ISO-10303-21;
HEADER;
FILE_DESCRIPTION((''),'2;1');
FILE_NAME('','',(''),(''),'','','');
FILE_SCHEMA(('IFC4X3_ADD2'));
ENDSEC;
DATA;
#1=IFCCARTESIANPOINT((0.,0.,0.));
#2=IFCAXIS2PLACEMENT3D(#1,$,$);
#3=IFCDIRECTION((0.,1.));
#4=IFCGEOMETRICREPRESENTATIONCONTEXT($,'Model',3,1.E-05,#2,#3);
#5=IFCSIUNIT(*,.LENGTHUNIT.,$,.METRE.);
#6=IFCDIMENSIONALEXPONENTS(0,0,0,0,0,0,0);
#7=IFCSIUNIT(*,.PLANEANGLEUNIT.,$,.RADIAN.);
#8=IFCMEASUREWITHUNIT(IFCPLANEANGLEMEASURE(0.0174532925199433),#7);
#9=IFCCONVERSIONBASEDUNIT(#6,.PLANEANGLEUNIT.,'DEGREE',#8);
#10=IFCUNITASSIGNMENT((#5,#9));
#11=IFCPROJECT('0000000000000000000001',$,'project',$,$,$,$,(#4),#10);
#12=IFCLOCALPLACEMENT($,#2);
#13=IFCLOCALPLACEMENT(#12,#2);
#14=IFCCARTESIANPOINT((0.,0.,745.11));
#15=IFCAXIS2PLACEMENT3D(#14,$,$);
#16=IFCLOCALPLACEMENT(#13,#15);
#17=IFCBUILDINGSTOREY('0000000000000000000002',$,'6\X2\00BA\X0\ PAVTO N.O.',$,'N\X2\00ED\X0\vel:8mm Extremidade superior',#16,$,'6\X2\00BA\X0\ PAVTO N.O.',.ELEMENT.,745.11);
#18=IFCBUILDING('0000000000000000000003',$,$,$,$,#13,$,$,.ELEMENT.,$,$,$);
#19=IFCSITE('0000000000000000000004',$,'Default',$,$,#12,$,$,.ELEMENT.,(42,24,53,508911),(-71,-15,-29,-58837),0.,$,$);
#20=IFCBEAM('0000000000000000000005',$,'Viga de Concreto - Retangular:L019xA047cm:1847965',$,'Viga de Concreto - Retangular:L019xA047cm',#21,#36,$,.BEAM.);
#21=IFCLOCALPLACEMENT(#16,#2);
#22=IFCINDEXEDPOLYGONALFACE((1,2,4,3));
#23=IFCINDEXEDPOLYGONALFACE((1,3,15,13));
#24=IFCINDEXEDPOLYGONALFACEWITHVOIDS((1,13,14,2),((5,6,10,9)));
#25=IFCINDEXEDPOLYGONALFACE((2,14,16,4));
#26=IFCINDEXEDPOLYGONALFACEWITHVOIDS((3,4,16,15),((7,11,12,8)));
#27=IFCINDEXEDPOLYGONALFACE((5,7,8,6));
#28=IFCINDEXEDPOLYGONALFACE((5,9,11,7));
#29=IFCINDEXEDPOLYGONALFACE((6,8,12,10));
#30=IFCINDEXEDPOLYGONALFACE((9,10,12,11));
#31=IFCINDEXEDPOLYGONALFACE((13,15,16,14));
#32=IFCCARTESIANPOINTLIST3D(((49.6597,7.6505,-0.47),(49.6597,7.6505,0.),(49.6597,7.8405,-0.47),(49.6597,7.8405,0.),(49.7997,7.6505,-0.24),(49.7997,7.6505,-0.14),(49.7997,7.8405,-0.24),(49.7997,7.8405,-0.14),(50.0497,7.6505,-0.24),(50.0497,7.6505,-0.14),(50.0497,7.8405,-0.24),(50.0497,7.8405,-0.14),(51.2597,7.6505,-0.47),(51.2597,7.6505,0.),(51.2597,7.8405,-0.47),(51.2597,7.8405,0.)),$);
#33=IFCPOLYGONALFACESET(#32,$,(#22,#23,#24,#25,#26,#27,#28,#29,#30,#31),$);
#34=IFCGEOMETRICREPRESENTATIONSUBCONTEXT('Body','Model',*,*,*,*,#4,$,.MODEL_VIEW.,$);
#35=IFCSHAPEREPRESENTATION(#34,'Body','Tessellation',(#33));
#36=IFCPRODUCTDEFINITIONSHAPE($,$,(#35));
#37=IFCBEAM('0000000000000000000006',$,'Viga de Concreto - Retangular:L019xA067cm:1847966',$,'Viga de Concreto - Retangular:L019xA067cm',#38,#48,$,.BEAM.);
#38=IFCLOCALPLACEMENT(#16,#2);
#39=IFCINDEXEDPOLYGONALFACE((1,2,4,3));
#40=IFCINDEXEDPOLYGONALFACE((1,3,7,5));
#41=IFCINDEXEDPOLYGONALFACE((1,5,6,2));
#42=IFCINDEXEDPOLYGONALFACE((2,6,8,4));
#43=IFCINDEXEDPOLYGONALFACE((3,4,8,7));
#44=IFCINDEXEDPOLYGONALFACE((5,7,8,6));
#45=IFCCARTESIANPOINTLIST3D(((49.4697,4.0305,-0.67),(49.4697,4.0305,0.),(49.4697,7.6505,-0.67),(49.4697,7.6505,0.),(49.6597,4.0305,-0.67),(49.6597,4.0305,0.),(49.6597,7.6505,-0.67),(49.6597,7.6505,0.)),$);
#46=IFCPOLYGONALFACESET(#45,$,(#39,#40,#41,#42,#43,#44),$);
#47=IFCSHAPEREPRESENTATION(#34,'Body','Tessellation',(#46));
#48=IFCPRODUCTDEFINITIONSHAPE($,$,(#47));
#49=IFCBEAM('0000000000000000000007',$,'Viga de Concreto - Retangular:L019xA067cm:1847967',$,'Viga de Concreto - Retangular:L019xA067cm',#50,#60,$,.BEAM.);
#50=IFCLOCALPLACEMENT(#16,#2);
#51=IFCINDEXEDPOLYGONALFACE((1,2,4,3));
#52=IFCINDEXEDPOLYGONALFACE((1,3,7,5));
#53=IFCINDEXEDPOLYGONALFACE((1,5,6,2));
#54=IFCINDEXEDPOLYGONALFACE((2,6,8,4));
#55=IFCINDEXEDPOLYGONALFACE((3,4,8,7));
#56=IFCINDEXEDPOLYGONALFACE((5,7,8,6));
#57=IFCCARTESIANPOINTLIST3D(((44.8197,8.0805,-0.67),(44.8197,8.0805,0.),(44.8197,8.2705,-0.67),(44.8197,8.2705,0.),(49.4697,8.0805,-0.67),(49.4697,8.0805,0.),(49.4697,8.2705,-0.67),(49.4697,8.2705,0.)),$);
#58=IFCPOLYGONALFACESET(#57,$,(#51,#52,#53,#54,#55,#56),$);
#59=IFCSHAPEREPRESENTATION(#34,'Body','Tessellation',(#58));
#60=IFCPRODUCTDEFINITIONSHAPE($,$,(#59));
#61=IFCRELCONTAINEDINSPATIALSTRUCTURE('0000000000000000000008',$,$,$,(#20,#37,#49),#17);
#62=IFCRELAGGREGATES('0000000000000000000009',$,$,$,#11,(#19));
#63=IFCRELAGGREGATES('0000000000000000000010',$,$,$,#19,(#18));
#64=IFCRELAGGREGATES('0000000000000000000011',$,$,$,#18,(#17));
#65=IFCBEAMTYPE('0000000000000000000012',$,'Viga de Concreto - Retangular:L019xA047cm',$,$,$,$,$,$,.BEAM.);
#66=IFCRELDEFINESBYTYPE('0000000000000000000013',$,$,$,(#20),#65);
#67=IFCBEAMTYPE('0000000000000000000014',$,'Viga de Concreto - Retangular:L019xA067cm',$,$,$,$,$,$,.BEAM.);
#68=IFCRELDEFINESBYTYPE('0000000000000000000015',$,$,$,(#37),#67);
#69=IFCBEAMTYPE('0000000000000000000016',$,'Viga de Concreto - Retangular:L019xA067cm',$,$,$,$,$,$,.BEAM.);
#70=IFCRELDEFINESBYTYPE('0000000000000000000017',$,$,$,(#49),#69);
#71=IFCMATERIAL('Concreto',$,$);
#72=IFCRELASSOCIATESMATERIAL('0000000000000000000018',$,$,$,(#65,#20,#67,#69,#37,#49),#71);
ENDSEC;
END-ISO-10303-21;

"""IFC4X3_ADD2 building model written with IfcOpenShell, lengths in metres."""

from ifc_helpers import new_model, entity, si_unit, converted_unit, direction, frame, frame_2d, origin, place, context, subcontext, project, spatial, rectangle, extrude, boolean, source, transform, mapped, material, material_profile, profile_set, profile_usage, type_object, type_shapes, element, save


model = new_model("IFC4X3_ADD2")

# Units and contexts
model_context = context("Model", 3, precision=1e-05, world=origin(), true_north=direction((0.0, 1.0)))
body_context = subcontext(model_context, "Body", "Model", "MODEL_VIEW")
ifc_project = project(units=[si_unit("LENGTHUNIT", "METRE"), converted_unit("PLANEANGLEUNIT", "DEGREE", entity("IfcPlaneAngleMeasure", 0.0174532925199433), si_unit("PLANEANGLEUNIT", "RADIAN"), dimensions=[0, 0, 0, 0, 0, 0, 0])], contexts=[model_context])

# Site, building, storey
site_placement = place(None, origin())
site = spatial("IfcSite", under=ifc_project, at=site_placement, Name="Default", CompositionType="ELEMENT", RefLatitude=(42, 24, 53, 508911), RefLongitude=(-71, -15, -29, -58837), RefElevation=0.0)
building_placement = place(site_placement, origin())
building = spatial("IfcBuilding", under=site, at=building_placement, CompositionType="ELEMENT")
storey_placement = place(building_placement, frame((0.0, 0.0, 745.11)))
storey = spatial("IfcBuildingStorey", under=building, at=storey_placement, Name="6º PAVTO N.O.", ObjectType="Nível:8mm Extremidade superior", LongName="6º PAVTO N.O.", CompositionType="ELEMENT", Elevation=745.11)

# Beams
ifc_material = material(Name="Concreto")
ifc_material_profile_1 = material_profile(ifc_material, rectangle(XDim=0.47, YDim=0.19, at=frame_2d((0.0, 0.0), x_axis=(0.0, 1.0))), Name="L019xA047cm")
ifc_profile_set_1 = profile_set([ifc_material_profile_1], Name="L019xA047cm")
beam_type_1 = type_object("IfcBeamType", Name="Viga de Concreto - Retangular:L019xA047cm", PredefinedType="BEAM", material=ifc_profile_set_1)
shared_shape_1 = source(origin(), body_context, "Body", "CSG", [
    boolean("DIFFERENCE", extrude(rectangle(XDim=0.47, YDim=0.19, at=frame_2d((0.0, 0.0), x_axis=(0.0, 1.0))), frame((49.6597, 7.7455, 744.875), z_axis=(1.0, 0.0, 0.0), x_axis=(0.0, 1.0, 0.0)), (0.0, 0.0, 1.0), 1.6), extrude(rectangle(XDim=0.1, YDim=0.25, at=frame_2d((0.0, 0.0), x_axis=(0.0, 1.0))), frame((49.9247, 7.8405, 744.92), z_axis=(0.0, -1.0, 0.0), x_axis=(-1.0, 0.0, 0.0)), (0.0, 0.0, 1.0), 0.19)),
])
type_shapes(beam_type_1, [shared_shape_1])
beam_1_placement = place(storey_placement, frame((0.0, 0.0, -745.11)))
element("IfcBeam", 1, at=beam_1_placement, inside=storey, type_object=beam_type_1, material=ifc_material, Name="Viga de Concreto - Retangular:L019xA047cm:1847965", ObjectType="Viga de Concreto - Retangular:L019xA047cm", PredefinedType="BEAM", context=body_context, shape_type="MappedRepresentation", body=[
    mapped(shared_shape_1, transform((0.0, 0.0, 0.0), scale=1.0)),
])
ifc_material_profile_2 = material_profile(ifc_material, rectangle(XDim=0.67, YDim=0.19, at=frame_2d((0.0, 0.0), x_axis=(0.0, 1.0))), Name="L019xA067cm")
ifc_profile_set_2 = profile_set([ifc_material_profile_2], Name="L019xA067cm")
ifc_profile_usage_1 = profile_usage(ifc_profile_set_2, cardinal=8)
beam_type_2 = type_object("IfcBeamType", Name="Viga de Concreto - Retangular:L019xA067cm", PredefinedType="BEAM", material=ifc_profile_set_2)
shared_shape_2 = source(origin(), body_context, "Body", "SweptSolid", [
    extrude(rectangle(XDim=0.67, YDim=0.19, at=frame_2d((0.0, 0.0), x_axis=(0.0, 1.0))), frame((49.5647, 4.0305, 744.775), z_axis=(0.0, 1.0, 0.0), x_axis=(-1.0, 0.0, 0.0)), (0.0, 0.0, 1.0), 3.62),
])
type_shapes(beam_type_2, [shared_shape_2])
beam_2_placement = place(storey_placement, frame((0.0, 0.0, -745.11)))
element("IfcBeam", 2, at=beam_2_placement, inside=storey, type_object=beam_type_2, material=ifc_profile_usage_1, Name="Viga de Concreto - Retangular:L019xA067cm:1847966", ObjectType="Viga de Concreto - Retangular:L019xA067cm", PredefinedType="BEAM", context=body_context, shape_type="MappedRepresentation", body=[
    mapped(shared_shape_2, transform((0.0, 0.0, 0.0), scale=1.0)),
])
beam_type_3 = type_object("IfcBeamType", Name="Viga de Concreto - Retangular:L019xA067cm", PredefinedType="BEAM", material=ifc_profile_set_2)
shared_shape_3 = source(origin(), body_context, "Body", "SweptSolid", [
    extrude(rectangle(XDim=0.67, YDim=0.19, at=frame_2d((0.0, 0.0), x_axis=(1.0, 0.0))), frame((44.8197, 8.1755, 744.775), z_axis=(1.0, 0.0, 0.0), x_axis=(0.0, 0.0, -1.0)), (0.0, 0.0, 1.0), 4.65),
])
type_shapes(beam_type_3, [shared_shape_3])
beam_3_placement = place(storey_placement, frame((0.0, 0.0, -745.11)))
element("IfcBeam", 3, at=beam_3_placement, inside=storey, type_object=beam_type_3, material=ifc_profile_usage_1, Name="Viga de Concreto - Retangular:L019xA067cm:1847967", ObjectType="Viga de Concreto - Retangular:L019xA067cm", PredefinedType="BEAM", context=body_context, shape_type="MappedRepresentation", body=[
    mapped(shared_shape_3, transform((0.0, 0.0, 0.0), scale=1.0)),
])

save(model, "model.ifc")
